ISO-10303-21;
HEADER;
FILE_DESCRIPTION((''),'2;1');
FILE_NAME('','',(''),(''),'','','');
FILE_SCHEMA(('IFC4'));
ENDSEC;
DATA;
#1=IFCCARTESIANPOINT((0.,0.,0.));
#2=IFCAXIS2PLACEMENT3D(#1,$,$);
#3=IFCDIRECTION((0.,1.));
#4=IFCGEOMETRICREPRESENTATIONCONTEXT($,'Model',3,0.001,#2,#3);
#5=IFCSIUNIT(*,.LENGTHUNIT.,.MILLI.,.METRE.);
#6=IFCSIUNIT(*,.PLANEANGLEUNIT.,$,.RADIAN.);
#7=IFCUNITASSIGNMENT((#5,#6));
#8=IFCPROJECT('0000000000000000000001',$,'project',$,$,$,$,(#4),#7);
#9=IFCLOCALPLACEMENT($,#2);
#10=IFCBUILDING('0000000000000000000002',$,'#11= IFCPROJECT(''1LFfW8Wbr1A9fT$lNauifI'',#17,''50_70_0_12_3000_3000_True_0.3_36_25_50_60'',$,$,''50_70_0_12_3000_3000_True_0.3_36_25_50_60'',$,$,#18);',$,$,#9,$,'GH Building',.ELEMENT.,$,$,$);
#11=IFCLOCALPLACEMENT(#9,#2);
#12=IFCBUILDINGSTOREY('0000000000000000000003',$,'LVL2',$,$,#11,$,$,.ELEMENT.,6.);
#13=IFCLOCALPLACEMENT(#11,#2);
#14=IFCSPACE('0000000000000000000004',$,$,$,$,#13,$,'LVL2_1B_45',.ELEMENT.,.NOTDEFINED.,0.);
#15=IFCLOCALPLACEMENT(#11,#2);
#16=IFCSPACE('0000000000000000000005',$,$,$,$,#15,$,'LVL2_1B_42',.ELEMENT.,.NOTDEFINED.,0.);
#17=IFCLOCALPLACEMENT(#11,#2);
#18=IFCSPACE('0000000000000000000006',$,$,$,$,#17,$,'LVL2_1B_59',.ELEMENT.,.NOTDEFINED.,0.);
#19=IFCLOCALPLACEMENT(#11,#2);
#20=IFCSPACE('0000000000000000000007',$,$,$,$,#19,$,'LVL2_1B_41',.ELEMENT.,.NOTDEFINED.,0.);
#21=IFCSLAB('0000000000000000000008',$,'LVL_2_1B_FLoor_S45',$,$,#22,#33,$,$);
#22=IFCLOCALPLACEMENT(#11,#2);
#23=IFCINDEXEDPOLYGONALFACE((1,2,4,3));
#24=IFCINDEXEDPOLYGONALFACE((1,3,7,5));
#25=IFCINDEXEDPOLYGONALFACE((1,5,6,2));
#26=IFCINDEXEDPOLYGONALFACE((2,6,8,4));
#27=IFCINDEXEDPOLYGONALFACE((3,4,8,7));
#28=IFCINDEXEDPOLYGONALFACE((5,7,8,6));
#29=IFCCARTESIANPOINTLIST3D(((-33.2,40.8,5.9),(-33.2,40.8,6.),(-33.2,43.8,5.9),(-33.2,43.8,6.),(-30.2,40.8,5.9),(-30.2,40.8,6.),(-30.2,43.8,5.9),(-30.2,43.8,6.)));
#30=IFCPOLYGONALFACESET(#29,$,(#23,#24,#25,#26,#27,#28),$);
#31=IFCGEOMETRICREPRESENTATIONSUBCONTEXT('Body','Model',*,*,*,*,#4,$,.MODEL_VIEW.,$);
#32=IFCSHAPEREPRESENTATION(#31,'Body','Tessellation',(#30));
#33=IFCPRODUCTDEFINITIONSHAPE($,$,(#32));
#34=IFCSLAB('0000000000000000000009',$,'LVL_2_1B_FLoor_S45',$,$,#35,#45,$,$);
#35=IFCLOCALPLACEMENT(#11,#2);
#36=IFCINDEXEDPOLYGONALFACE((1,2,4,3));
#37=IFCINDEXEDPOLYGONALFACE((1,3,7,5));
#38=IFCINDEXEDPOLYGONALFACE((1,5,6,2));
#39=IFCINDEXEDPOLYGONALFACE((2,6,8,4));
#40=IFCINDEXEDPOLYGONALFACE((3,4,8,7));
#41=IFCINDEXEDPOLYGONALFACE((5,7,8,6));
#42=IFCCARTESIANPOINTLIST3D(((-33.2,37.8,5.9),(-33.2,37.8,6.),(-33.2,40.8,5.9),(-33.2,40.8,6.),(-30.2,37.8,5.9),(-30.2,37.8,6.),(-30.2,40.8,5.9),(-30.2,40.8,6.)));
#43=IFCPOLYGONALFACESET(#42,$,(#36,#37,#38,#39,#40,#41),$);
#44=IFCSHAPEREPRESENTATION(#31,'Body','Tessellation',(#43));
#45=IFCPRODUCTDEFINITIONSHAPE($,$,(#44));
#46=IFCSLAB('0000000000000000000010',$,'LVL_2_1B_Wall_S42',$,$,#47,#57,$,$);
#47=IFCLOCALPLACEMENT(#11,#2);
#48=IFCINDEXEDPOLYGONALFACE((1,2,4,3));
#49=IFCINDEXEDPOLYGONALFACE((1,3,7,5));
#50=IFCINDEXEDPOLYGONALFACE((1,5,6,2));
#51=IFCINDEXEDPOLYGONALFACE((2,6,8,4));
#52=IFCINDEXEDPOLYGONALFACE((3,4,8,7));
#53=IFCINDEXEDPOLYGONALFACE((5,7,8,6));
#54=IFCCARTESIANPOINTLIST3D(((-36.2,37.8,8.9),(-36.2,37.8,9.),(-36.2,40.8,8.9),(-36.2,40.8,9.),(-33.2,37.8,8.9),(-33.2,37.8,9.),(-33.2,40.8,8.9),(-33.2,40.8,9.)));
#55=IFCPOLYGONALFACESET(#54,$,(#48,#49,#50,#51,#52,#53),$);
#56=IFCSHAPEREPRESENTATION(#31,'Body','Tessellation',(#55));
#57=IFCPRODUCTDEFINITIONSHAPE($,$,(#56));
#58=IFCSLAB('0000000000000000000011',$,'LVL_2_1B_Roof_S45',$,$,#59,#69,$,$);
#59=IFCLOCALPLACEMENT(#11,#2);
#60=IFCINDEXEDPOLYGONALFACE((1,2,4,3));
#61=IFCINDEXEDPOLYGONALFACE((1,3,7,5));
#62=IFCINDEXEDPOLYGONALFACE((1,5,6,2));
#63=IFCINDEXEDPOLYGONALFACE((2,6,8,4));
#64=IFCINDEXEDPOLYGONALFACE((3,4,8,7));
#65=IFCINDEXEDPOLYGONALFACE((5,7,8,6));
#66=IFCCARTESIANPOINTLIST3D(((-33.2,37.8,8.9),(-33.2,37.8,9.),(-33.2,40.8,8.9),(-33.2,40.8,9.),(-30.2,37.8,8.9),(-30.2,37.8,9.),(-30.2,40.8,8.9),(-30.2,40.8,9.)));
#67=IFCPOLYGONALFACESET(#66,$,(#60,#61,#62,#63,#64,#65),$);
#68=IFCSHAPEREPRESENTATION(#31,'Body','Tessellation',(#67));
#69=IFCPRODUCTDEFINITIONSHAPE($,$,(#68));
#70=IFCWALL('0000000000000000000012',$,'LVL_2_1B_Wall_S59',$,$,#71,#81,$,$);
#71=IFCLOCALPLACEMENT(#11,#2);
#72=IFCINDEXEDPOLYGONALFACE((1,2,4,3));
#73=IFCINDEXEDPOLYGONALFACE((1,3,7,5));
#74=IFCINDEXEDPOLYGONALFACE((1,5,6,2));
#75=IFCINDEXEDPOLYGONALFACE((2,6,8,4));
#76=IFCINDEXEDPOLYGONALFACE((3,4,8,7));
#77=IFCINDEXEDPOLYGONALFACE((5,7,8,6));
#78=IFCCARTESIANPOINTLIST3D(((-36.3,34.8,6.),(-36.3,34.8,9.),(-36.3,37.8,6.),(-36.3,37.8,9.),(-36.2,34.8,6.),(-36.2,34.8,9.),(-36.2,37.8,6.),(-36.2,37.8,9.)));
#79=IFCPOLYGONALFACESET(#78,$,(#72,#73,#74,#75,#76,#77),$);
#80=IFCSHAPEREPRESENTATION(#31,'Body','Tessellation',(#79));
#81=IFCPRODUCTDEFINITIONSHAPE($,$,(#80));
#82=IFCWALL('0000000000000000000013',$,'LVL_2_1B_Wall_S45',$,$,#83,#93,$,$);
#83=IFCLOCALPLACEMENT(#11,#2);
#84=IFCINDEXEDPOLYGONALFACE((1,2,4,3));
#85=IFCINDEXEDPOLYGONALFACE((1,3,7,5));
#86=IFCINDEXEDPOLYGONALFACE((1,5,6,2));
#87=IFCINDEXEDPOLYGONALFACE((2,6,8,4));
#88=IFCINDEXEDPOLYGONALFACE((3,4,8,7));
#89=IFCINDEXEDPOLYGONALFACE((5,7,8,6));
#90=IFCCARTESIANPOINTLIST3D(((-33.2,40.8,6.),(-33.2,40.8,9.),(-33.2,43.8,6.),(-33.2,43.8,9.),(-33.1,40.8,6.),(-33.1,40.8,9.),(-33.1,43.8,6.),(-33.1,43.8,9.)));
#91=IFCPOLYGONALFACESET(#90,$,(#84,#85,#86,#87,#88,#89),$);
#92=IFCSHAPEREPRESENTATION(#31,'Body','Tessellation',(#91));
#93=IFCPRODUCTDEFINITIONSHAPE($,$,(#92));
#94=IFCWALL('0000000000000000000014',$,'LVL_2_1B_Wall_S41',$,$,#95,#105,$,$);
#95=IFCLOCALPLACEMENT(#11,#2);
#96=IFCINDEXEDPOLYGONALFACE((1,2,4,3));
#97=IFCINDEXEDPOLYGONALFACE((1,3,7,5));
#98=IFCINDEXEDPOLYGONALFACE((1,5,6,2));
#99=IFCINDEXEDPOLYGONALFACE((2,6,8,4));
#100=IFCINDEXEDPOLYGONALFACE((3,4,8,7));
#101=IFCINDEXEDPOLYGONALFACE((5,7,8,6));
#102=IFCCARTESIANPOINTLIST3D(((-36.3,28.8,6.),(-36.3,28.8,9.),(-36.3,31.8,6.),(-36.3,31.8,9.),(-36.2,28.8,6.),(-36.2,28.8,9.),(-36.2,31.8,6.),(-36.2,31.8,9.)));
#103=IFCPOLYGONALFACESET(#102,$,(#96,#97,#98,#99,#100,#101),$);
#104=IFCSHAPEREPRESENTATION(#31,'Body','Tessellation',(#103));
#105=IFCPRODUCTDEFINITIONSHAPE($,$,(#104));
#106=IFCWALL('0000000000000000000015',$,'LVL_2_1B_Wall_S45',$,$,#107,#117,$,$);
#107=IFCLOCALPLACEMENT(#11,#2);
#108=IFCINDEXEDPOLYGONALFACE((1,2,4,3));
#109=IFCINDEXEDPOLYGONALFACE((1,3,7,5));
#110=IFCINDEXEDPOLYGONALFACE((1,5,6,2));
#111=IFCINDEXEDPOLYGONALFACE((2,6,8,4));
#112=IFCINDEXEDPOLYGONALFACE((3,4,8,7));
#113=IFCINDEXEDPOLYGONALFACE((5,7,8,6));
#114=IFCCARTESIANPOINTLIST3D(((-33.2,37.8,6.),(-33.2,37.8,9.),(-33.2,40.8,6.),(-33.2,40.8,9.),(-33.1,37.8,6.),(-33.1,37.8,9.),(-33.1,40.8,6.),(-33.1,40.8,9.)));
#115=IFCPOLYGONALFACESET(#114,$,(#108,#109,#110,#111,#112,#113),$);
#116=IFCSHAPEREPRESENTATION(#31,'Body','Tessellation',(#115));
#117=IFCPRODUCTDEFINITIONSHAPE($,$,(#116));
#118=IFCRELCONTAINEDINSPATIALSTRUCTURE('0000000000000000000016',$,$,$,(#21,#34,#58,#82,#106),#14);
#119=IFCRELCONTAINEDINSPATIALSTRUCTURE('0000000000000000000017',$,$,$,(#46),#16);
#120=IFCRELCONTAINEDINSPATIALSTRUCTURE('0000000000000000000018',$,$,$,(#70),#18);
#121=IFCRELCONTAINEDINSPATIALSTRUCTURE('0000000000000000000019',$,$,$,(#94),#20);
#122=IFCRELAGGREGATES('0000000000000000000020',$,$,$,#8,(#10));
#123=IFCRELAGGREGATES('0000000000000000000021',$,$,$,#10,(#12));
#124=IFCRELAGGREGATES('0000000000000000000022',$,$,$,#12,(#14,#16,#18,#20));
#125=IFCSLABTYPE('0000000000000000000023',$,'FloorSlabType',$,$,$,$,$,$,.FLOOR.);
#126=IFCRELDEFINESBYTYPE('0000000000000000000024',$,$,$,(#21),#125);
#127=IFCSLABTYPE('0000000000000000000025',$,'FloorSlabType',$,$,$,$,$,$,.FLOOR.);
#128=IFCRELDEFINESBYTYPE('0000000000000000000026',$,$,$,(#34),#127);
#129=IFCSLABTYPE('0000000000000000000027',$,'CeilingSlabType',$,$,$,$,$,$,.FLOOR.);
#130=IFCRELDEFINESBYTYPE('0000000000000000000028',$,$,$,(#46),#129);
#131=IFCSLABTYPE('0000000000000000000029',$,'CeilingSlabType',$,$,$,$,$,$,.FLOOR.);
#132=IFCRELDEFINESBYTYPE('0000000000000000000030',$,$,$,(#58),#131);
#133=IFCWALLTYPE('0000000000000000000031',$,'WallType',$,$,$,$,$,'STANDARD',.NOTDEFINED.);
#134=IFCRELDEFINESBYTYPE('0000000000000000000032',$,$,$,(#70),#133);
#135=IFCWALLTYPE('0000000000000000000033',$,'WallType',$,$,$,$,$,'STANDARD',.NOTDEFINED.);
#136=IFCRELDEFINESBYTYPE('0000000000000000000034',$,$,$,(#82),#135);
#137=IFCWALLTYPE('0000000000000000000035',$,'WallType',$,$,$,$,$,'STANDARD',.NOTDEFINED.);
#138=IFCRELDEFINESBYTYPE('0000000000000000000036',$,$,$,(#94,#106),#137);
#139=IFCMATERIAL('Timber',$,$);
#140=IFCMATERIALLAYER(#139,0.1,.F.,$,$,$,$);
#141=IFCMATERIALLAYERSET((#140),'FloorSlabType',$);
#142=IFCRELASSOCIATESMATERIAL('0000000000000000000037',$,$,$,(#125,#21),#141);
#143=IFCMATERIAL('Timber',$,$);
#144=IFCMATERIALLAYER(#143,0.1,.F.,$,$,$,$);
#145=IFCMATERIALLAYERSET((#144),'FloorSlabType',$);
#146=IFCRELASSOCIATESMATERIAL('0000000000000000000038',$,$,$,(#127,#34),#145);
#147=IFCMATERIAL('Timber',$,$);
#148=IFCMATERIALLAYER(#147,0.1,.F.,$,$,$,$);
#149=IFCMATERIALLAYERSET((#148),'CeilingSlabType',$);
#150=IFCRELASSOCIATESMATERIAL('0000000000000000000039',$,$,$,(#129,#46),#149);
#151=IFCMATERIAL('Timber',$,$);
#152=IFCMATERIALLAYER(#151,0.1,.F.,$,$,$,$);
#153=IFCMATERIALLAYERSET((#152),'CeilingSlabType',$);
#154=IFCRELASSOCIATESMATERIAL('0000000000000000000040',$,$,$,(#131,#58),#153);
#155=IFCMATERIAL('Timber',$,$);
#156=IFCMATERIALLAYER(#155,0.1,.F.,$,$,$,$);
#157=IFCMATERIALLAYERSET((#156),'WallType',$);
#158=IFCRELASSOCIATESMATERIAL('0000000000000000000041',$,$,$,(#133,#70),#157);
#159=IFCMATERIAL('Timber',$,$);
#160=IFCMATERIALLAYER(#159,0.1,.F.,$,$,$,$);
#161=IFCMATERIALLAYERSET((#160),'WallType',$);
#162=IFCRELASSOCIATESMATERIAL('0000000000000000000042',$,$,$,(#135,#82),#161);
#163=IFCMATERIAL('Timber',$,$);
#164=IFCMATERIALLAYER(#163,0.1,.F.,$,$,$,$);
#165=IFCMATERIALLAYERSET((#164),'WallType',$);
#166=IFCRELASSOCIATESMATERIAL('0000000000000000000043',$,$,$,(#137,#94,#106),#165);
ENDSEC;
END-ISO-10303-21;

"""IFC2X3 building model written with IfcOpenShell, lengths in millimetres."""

from ifc_helpers import new_model, si_unit, direction, frame, frame_2d, origin, place, context, subcontext, project, spatial, rectangle, extrude, material, layer, layer_set, layer_usage, type_object, element, save


model = new_model("IFC2X3")

# Units and contexts
model_context = context("Model", 3, precision=0.001, world=origin(), true_north=direction((0.0, 1.0)))
body_context = subcontext(model_context, "Body", "Model", "MODEL_VIEW")
ifc_project = project(units=[si_unit("LENGTHUNIT", "METRE", prefix="MILLI"), si_unit("PLANEANGLEUNIT", "RADIAN")], contexts=[model_context])

# Building, storey
building_placement = place(None, origin())
building = spatial("IfcBuilding", under=ifc_project, at=building_placement, Name="#11= IFCPROJECT('1LFfW8Wbr1A9fT$lNauifI',#17,'50_70_0_12_3000_3000_True_0.3_36_25_50_60',$,$,'50_70_0_12_3000_3000_True_0.3_36_25_50_60',$,$,#18);", LongName="GH Building", CompositionType="ELEMENT")
storey_placement = place(building_placement, origin())
storey = spatial("IfcBuildingStorey", under=building, at=storey_placement, Name="LVL2", CompositionType="ELEMENT", Elevation=6.0)

# Shared definitions
space_1_placement = place(storey_placement, origin())
space_1 = spatial("IfcSpace", under=storey, at=space_1_placement, LongName="LVL2_1B_45", CompositionType="ELEMENT", InteriorOrExteriorSpace="NOTDEFINED", ElevationWithFlooring=0.0)

# Slabs
ifc_material_1 = material(Name="Timber")
ifc_layer_1 = layer(ifc_material_1, 0.1, ventilated=False)
ifc_layer_set_1 = layer_set([ifc_layer_1], Name="FloorSlabType")
ifc_layer_usage_1 = layer_usage(ifc_layer_set_1, "AXIS3", "NEGATIVE", -0.1)
slab_type_1 = type_object("IfcSlabType", Name="FloorSlabType", PredefinedType="FLOOR", material=ifc_layer_set_1)
slab_1_placement = place(space_1_placement, frame((-33.2, 43.8, 5.9), z_axis=(0.0, 0.0, 1.0), x_axis=(0.0, -1.0, 0.0)))
element("IfcSlab", 1, at=slab_1_placement, inside=space_1, type_object=slab_type_1, material=ifc_layer_usage_1, Name="LVL_2_1B_FLoor_S45", context=body_context, shape_type="SweptSolid", body=[
    extrude(rectangle(XDim=3.0, YDim=3.0, at=frame_2d((1.5, 1.5))), origin(), (0.0, 0.0, 1.0), 0.1),
])
ifc_material_2 = material(Name="Timber")
ifc_layer_2 = layer(ifc_material_2, 0.1, ventilated=False)
ifc_layer_set_2 = layer_set([ifc_layer_2], Name="FloorSlabType")
ifc_layer_usage_2 = layer_usage(ifc_layer_set_2, "AXIS3", "NEGATIVE", -0.1)
slab_type_2 = type_object("IfcSlabType", Name="FloorSlabType", PredefinedType="FLOOR", material=ifc_layer_set_2)
slab_2_placement = place(space_1_placement, frame((-33.2, 40.8, 5.9), z_axis=(0.0, 0.0, 1.0), x_axis=(0.0, -1.0, 0.0)))
element("IfcSlab", 2, at=slab_2_placement, inside=space_1, type_object=slab_type_2, material=ifc_layer_usage_2, Name="LVL_2_1B_FLoor_S45", context=body_context, shape_type="SweptSolid", body=[
    extrude(rectangle(XDim=3.0, YDim=3.0, at=frame_2d((1.5, 1.5))), origin(), (0.0, 0.0, 1.0), 0.1),
])

# Shared definitions
space_2_placement = place(storey_placement, origin())
space_2 = spatial("IfcSpace", under=storey, at=space_2_placement, LongName="LVL2_1B_42", CompositionType="ELEMENT", InteriorOrExteriorSpace="NOTDEFINED", ElevationWithFlooring=0.0)

# Slabs
ifc_material_3 = material(Name="Timber")
ifc_layer_3 = layer(ifc_material_3, 0.1, ventilated=False)
ifc_layer_set_3 = layer_set([ifc_layer_3], Name="CeilingSlabType")
ifc_layer_usage_3 = layer_usage(ifc_layer_set_3, "AXIS3", "NEGATIVE", -0.1)
slab_type_3 = type_object("IfcSlabType", Name="CeilingSlabType", PredefinedType="FLOOR", material=ifc_layer_set_3)
slab_3_placement = place(space_2_placement, frame((-36.2, 40.8, 8.9), z_axis=(0.0, 0.0, 1.0), x_axis=(0.0, -1.0, 0.0)))
element("IfcSlab", 3, at=slab_3_placement, inside=space_2, type_object=slab_type_3, material=ifc_layer_usage_3, Name="LVL_2_1B_Wall_S42", context=body_context, shape_type="SweptSolid", body=[
    extrude(rectangle(XDim=3.0, YDim=3.0, at=frame_2d((1.5, 1.5))), origin(), (0.0, 0.0, 1.0), 0.1),
])
ifc_material_4 = material(Name="Timber")
ifc_layer_4 = layer(ifc_material_4, 0.1, ventilated=False)
ifc_layer_set_4 = layer_set([ifc_layer_4], Name="CeilingSlabType")
ifc_layer_usage_4 = layer_usage(ifc_layer_set_4, "AXIS3", "NEGATIVE", -0.1)
slab_type_4 = type_object("IfcSlabType", Name="CeilingSlabType", PredefinedType="FLOOR", material=ifc_layer_set_4)
slab_4_placement = place(space_1_placement, frame((-33.2, 40.8, 8.9), z_axis=(0.0, 0.0, 1.0), x_axis=(0.0, -1.0, 0.0)))
element("IfcSlab", 4, at=slab_4_placement, inside=space_1, type_object=slab_type_4, material=ifc_layer_usage_4, Name="LVL_2_1B_Roof_S45", context=body_context, shape_type="SweptSolid", body=[
    extrude(rectangle(XDim=3.0, YDim=3.0, at=frame_2d((1.5, 1.5))), origin(), (0.0, 0.0, 1.0), 0.1),
])

# Shared definitions
space_3_placement = place(storey_placement, origin())
space_3 = spatial("IfcSpace", under=storey, at=space_3_placement, LongName="LVL2_1B_59", CompositionType="ELEMENT", InteriorOrExteriorSpace="NOTDEFINED", ElevationWithFlooring=0.0)

# Walls
ifc_material_5 = material(Name="Timber")
ifc_layer_5 = layer(ifc_material_5, 0.1, ventilated=False)
ifc_layer_set_5 = layer_set([ifc_layer_5], Name="WallType")
ifc_layer_usage_5 = layer_usage(ifc_layer_set_5, "AXIS2", "NEGATIVE", 0.0)
wall_type_1 = type_object("IfcWallType", Name="WallType", ElementType="STANDARD", PredefinedType="NOTDEFINED", material=ifc_layer_set_5)
wall_1_placement = place(space_3_placement, frame((-36.2, 37.8, 6.0), z_axis=(0.0, 0.0, 1.0), x_axis=(0.0, -1.0, 0.0)))
element("IfcWall", 5, at=wall_1_placement, inside=space_3, type_object=wall_type_1, material=ifc_layer_usage_5, Name="LVL_2_1B_Wall_S59", context=body_context, shape_type="SweptSolid", body=[
    extrude(rectangle(XDim=3.0, YDim=0.1, at=frame_2d((1.5, -0.1))), origin(), (0.0, 0.0, 1.0), 3.0),
])
ifc_material_6 = material(Name="Timber")
ifc_layer_6 = layer(ifc_material_6, 0.1, ventilated=False)
ifc_layer_set_6 = layer_set([ifc_layer_6], Name="WallType")
ifc_layer_usage_6 = layer_usage(ifc_layer_set_6, "AXIS2", "NEGATIVE", 0.0)
wall_type_2 = type_object("IfcWallType", Name="WallType", ElementType="STANDARD", PredefinedType="NOTDEFINED", material=ifc_layer_set_6)
wall_2_placement = place(space_1_placement, frame((-33.2, 40.8, 6.0), z_axis=(0.0, 0.0, 1.0), x_axis=(0.0, 1.0, 0.0)))
element("IfcWall", 6, at=wall_2_placement, inside=space_1, type_object=wall_type_2, material=ifc_layer_usage_6, Name="LVL_2_1B_Wall_S45", context=body_context, shape_type="SweptSolid", body=[
    extrude(rectangle(XDim=3.0, YDim=0.1, at=frame_2d((1.5, -0.1))), origin(), (0.0, 0.0, 1.0), 3.0),
])

# Shared definitions
space_4_placement = place(storey_placement, origin())
space_4 = spatial("IfcSpace", under=storey, at=space_4_placement, LongName="LVL2_1B_41", CompositionType="ELEMENT", InteriorOrExteriorSpace="NOTDEFINED", ElevationWithFlooring=0.0)

# Walls
ifc_material_7 = material(Name="Timber")
ifc_layer_7 = layer(ifc_material_7, 0.1, ventilated=False)
ifc_layer_set_7 = layer_set([ifc_layer_7], Name="WallType")
ifc_layer_usage_7 = layer_usage(ifc_layer_set_7, "AXIS2", "NEGATIVE", 0.0)
wall_type_3 = type_object("IfcWallType", Name="WallType", ElementType="STANDARD", PredefinedType="NOTDEFINED", material=ifc_layer_set_7)
wall_3_placement = place(space_4_placement, frame((-36.2, 31.8, 6.0), z_axis=(0.0, 0.0, 1.0), x_axis=(0.0, -1.0, 0.0)))
element("IfcWall", 7, at=wall_3_placement, inside=space_4, type_object=wall_type_3, material=ifc_layer_usage_7, Name="LVL_2_1B_Wall_S41", context=body_context, shape_type="SweptSolid", body=[
    extrude(rectangle(XDim=3.0, YDim=0.1, at=frame_2d((1.5, -0.1))), origin(), (0.0, 0.0, 1.0), 3.0),
])
ifc_layer_usage_8 = layer_usage(ifc_layer_set_7, "AXIS2", "NEGATIVE", 0.0)
wall_4_placement = place(space_1_placement, frame((-33.2, 37.8, 6.0), z_axis=(0.0, 0.0, 1.0), x_axis=(0.0, 1.0, 0.0)))
element("IfcWall", 8, at=wall_4_placement, inside=space_1, type_object=wall_type_3, material=ifc_layer_usage_8, Name="LVL_2_1B_Wall_S45", context=body_context, shape_type="SweptSolid", body=[
    extrude(rectangle(XDim=3.0, YDim=0.1, at=frame_2d((1.5, -0.1))), origin(), (0.0, 0.0, 1.0), 3.0),
])

save(model, "model.ifc")
